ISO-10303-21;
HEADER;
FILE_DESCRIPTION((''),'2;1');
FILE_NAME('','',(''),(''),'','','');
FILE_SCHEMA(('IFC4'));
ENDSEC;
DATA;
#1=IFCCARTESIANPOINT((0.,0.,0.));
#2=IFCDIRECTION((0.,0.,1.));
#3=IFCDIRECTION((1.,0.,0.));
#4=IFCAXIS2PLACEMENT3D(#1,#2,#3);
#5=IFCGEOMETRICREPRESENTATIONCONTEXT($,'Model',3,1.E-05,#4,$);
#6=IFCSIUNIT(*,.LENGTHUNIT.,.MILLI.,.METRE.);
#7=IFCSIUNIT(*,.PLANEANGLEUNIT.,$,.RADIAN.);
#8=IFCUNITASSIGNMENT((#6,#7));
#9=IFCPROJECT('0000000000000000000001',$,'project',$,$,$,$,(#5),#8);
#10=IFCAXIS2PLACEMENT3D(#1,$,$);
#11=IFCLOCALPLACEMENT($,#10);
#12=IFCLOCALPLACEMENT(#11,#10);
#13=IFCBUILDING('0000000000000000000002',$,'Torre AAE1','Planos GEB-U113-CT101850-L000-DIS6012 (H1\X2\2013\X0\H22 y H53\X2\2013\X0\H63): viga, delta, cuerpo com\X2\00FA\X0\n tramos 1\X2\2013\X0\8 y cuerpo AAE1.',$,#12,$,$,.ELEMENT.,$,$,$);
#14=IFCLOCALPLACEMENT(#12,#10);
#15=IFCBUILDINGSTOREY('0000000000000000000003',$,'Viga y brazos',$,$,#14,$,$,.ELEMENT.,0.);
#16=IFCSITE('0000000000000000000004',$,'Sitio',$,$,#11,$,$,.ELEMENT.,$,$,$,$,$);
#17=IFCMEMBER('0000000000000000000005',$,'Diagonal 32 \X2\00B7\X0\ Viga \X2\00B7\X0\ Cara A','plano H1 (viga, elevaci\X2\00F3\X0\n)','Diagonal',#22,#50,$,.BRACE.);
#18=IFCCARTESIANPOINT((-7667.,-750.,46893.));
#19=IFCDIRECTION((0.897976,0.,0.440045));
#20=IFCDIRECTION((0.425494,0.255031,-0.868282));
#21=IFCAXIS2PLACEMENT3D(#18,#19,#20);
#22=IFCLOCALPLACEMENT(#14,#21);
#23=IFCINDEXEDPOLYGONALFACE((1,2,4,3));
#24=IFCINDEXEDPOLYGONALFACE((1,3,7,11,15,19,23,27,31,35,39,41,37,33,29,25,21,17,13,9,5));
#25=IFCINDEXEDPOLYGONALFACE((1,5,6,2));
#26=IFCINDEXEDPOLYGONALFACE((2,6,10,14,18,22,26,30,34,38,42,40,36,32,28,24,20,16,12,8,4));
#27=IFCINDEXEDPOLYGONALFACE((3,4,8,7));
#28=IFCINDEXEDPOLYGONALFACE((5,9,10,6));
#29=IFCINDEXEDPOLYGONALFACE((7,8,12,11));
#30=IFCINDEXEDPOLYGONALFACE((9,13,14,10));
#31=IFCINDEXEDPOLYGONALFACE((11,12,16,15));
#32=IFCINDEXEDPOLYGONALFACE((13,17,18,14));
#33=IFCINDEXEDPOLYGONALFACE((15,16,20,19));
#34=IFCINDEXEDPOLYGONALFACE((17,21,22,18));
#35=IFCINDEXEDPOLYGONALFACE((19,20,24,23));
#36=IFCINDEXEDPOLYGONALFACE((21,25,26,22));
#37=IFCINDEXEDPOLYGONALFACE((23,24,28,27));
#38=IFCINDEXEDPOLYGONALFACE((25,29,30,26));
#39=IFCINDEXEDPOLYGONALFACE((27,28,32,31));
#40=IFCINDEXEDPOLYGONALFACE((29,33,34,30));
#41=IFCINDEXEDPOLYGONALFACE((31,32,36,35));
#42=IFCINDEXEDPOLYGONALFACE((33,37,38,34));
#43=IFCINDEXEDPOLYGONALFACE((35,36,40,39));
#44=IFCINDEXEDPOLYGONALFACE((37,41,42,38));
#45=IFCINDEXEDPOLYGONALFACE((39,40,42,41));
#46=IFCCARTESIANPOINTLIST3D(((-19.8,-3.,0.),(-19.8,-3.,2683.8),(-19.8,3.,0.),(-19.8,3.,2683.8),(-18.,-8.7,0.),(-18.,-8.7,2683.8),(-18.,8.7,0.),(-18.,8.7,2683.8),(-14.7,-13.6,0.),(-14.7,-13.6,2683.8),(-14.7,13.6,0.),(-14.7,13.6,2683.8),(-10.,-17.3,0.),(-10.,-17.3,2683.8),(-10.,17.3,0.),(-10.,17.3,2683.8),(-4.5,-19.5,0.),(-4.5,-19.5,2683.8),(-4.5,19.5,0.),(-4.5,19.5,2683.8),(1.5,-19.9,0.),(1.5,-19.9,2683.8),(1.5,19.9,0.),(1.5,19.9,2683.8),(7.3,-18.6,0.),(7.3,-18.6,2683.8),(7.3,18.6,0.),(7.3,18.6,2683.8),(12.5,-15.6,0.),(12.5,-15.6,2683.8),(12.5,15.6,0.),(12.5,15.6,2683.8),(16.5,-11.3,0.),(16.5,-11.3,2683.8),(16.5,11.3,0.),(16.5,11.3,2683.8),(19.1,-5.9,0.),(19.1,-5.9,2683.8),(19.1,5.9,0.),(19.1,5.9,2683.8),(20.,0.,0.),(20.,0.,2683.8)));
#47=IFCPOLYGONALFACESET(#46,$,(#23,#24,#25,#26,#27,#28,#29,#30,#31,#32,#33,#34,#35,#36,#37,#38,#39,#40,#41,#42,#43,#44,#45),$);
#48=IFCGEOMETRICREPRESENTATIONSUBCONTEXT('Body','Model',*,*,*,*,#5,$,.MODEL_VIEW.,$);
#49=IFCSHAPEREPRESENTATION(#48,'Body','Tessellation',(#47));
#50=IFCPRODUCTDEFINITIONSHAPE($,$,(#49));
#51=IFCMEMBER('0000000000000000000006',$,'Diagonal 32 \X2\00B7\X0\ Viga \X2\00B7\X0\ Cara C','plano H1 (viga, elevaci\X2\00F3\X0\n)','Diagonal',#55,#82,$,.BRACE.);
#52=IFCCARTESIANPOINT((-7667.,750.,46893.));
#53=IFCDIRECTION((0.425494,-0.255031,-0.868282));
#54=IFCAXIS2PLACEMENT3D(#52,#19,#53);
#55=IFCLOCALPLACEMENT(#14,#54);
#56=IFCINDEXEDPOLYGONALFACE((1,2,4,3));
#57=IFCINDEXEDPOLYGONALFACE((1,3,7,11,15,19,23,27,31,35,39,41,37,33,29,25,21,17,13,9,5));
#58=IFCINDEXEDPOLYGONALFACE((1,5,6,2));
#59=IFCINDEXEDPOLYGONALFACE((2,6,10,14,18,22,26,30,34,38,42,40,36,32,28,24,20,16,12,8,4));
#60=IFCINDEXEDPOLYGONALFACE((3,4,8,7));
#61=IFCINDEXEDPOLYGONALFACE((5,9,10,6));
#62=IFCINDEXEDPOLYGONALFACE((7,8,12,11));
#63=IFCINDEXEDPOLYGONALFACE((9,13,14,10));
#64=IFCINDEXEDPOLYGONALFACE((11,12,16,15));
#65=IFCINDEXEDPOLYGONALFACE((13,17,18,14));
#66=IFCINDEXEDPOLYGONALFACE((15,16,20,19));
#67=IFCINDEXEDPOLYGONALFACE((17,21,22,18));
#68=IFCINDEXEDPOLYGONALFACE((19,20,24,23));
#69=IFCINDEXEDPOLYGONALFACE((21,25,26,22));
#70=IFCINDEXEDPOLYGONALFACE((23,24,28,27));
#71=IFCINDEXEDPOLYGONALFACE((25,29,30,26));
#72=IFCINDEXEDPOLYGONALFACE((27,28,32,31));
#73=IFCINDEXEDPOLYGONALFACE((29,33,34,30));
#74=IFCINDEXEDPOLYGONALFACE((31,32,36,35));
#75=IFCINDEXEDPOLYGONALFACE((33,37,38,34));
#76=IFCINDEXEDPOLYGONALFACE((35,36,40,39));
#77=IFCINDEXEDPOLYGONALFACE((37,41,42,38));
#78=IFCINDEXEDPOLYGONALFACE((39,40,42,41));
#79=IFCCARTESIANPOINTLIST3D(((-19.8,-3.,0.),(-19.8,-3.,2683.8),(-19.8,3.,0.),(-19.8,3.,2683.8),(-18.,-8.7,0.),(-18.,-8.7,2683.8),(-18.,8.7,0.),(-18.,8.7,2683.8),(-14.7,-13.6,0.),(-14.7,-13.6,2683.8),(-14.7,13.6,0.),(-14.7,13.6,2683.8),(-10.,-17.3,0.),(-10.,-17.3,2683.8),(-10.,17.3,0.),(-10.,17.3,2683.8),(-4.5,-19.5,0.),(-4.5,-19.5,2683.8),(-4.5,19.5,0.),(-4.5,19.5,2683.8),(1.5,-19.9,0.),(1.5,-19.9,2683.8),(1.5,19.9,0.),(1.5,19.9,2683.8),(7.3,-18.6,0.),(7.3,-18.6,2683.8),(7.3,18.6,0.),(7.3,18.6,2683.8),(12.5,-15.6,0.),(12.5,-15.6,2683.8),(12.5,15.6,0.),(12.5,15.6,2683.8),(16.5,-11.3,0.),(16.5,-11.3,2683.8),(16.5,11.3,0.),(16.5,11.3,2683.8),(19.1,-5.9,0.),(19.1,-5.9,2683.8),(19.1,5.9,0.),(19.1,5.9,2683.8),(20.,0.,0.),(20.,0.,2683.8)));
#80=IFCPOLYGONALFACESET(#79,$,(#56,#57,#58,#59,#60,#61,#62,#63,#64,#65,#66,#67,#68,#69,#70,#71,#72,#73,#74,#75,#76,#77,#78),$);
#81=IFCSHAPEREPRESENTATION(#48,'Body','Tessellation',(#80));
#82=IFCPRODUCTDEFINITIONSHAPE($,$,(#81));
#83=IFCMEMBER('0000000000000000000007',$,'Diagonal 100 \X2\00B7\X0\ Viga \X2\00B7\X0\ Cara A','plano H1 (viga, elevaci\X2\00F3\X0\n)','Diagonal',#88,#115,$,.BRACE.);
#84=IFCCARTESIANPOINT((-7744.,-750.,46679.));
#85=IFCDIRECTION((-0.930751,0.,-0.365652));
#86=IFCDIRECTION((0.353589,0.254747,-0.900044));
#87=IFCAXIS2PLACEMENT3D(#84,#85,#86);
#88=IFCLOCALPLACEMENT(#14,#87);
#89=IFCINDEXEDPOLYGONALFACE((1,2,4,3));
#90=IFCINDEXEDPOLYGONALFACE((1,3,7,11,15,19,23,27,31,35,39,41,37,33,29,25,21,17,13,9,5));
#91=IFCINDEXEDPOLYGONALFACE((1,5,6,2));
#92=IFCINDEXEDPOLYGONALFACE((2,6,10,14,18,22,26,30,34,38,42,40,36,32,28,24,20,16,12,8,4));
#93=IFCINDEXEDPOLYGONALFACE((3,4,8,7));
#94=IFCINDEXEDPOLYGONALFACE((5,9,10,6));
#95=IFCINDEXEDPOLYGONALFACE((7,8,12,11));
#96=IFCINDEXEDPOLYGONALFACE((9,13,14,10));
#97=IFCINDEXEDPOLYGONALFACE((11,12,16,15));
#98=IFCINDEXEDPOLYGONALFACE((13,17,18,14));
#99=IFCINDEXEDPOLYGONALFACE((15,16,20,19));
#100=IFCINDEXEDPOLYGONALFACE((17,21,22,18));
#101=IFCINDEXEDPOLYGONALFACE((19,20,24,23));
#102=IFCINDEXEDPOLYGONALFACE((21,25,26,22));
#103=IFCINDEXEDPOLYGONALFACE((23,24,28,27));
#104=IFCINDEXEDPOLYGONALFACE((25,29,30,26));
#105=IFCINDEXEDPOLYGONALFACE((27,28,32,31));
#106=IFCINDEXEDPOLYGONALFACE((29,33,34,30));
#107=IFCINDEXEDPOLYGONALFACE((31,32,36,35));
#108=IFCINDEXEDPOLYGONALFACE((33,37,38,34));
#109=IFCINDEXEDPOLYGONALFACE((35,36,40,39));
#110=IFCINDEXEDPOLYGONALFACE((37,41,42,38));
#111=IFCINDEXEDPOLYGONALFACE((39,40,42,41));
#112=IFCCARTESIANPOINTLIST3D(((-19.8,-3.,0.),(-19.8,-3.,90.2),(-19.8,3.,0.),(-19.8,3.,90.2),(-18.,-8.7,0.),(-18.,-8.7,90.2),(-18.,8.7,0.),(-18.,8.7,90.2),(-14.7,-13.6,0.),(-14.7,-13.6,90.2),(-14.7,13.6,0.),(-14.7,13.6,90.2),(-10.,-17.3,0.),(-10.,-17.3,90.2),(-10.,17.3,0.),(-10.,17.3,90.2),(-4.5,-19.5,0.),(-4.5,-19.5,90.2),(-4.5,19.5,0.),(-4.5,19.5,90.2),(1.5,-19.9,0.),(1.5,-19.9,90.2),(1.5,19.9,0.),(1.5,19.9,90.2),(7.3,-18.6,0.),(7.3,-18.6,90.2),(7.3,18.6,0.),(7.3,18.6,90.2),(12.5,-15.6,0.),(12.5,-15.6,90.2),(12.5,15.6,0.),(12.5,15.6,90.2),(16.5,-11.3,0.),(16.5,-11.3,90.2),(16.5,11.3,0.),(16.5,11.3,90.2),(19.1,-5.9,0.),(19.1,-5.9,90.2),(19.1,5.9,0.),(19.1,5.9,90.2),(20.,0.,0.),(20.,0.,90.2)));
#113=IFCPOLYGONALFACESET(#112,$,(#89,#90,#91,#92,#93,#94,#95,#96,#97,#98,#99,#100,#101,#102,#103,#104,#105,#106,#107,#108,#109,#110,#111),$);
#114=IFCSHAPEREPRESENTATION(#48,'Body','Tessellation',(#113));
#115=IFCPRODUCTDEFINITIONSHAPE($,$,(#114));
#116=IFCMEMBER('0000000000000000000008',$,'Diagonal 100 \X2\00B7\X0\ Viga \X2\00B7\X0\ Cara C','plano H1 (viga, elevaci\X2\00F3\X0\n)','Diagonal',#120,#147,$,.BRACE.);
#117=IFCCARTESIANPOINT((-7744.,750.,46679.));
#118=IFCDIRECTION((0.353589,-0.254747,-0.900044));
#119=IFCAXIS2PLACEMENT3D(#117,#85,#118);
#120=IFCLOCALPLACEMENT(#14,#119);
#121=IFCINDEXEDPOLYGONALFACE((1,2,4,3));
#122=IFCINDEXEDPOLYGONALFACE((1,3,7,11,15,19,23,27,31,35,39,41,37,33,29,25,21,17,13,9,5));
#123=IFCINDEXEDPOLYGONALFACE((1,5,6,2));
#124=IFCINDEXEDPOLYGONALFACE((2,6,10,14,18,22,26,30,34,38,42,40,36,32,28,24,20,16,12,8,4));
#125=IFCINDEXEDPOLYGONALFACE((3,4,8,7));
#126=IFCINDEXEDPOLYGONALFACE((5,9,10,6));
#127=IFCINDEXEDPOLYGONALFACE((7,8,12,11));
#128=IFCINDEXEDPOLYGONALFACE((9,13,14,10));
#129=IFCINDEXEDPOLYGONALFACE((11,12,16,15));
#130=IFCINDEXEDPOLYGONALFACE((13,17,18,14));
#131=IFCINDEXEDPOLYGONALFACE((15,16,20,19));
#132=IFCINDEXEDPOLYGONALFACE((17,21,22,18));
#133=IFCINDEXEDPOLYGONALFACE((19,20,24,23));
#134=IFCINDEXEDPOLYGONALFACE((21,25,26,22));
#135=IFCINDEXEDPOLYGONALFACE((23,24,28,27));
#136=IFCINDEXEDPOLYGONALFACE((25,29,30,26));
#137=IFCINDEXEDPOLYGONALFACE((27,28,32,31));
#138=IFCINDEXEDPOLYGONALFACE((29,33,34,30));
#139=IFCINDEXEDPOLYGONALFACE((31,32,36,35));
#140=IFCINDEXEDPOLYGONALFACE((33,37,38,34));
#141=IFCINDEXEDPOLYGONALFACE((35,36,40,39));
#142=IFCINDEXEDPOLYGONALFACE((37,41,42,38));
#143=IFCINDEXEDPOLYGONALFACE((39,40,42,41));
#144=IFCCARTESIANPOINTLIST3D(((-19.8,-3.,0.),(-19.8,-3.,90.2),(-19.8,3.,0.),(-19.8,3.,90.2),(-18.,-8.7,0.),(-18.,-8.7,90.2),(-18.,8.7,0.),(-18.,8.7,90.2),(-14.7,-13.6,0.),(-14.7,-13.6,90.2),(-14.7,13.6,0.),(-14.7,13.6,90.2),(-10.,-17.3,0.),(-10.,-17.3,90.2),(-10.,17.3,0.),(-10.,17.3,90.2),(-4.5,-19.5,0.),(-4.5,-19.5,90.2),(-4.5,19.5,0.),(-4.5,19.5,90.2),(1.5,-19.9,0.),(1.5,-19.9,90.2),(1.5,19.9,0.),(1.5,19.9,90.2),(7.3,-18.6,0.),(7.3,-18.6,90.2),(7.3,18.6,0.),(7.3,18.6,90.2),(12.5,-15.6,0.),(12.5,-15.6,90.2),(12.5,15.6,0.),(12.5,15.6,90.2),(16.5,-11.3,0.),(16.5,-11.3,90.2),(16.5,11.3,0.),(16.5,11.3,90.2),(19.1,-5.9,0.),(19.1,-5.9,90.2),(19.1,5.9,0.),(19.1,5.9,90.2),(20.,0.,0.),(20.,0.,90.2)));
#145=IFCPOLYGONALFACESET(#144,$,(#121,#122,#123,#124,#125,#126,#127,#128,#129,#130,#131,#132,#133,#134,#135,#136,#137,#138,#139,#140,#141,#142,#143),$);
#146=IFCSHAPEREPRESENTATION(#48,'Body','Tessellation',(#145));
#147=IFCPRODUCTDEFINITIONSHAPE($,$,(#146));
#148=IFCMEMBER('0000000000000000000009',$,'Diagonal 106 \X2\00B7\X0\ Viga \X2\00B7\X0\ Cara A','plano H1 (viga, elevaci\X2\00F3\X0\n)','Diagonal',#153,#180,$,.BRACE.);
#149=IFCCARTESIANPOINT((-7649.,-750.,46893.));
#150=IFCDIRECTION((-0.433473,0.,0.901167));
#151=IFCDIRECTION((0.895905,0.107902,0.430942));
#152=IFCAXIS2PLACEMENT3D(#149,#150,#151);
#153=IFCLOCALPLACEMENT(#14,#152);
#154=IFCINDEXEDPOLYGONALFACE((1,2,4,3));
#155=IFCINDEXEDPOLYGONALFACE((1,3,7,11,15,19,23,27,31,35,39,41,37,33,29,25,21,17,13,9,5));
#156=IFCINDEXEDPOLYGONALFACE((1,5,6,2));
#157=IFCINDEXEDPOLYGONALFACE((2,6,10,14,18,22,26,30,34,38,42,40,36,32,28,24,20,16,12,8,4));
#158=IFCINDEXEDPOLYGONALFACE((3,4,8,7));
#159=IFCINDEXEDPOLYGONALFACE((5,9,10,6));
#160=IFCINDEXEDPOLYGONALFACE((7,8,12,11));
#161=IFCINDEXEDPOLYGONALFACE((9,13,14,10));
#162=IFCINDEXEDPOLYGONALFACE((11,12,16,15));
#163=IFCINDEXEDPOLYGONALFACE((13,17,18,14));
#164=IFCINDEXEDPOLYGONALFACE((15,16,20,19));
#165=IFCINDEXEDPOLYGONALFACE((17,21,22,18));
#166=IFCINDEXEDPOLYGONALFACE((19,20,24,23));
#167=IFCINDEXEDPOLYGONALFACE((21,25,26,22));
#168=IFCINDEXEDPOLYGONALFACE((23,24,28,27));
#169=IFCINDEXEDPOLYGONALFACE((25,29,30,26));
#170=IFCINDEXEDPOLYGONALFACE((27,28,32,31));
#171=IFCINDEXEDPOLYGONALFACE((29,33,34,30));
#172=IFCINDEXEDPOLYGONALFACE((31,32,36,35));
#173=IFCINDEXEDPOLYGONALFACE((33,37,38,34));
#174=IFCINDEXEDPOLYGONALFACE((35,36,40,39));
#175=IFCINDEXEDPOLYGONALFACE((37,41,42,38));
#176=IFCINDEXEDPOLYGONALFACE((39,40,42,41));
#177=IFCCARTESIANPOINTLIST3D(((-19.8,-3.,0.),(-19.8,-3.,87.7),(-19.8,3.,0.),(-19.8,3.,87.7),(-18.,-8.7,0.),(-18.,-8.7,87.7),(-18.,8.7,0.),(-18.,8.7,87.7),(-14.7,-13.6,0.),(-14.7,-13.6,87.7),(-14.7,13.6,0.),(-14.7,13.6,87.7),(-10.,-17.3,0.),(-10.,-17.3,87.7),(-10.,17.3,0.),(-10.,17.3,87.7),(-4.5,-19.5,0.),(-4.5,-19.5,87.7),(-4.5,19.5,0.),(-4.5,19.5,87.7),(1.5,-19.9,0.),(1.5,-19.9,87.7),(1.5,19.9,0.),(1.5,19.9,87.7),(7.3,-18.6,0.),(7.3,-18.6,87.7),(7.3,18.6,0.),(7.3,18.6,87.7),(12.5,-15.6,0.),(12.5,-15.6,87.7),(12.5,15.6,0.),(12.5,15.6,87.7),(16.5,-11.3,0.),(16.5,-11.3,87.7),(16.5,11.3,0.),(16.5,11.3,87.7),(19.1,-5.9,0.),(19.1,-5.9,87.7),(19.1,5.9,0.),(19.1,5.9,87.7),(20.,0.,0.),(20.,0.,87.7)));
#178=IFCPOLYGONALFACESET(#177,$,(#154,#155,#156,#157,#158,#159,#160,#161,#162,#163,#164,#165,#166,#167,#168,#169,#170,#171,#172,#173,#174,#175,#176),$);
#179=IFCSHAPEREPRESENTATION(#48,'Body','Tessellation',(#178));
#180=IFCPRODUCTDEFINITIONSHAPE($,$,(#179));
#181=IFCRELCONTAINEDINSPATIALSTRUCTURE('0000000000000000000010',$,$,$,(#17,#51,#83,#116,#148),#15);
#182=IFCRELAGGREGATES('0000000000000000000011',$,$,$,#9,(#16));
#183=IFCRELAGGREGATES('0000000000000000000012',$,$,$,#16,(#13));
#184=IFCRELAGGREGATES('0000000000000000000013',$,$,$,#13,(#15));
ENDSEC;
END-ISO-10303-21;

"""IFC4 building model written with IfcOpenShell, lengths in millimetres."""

from ifc_helpers import new_model, si_unit, frame, origin, origin_with_axes, place, context, subcontext, project, spatial, circle, extrude, element, save


model = new_model("IFC4")

# Units and contexts
model_context = context("Model", 3, precision=1e-05, world=origin_with_axes())
body_context = subcontext(model_context, "Body", "Model", "MODEL_VIEW")
ifc_project = project(units=[si_unit("LENGTHUNIT", "METRE", prefix="MILLI"), si_unit("PLANEANGLEUNIT", "RADIAN")], contexts=[model_context])

# Site, building, storey
site_placement = place(None, origin())
site = spatial("IfcSite", under=ifc_project, at=site_placement, Name="Sitio", CompositionType="ELEMENT")
building_placement = place(site_placement, origin())
building = spatial("IfcBuilding", under=site, at=building_placement, Name="Torre AAE1", Description="Planos GEB-U113-CT101850-L000-DIS6012 (H1–H22 y H53–H63): viga, delta, cuerpo común tramos 1–8 y cuerpo AAE1.", CompositionType="ELEMENT")
storey_placement = place(building_placement, origin())
storey = spatial("IfcBuildingStorey", under=building, at=storey_placement, Name="Viga y brazos", CompositionType="ELEMENT", Elevation=0.0)

# Members
for number, where, z_axis, x_axis, name in (
    (1, (-7667.0, -750.0, 46893.0), (0.897976, 0.0, 0.440045), (0.425494, 0.255031, -0.868282), "Diagonal 32 · Viga · Cara A"),
    (2, (-7667.0, 750.0, 46893.0), (0.897976, 0.0, 0.440045), (0.425494, -0.255031, -0.868282), "Diagonal 32 · Viga · Cara C"),
):
    element("IfcMember", number, at=place(storey_placement, frame(where, z_axis=z_axis, x_axis=x_axis)), inside=storey, Name=name, Description="plano H1 (viga, elevación)", ObjectType="Diagonal", PredefinedType="BRACE", context=body_context, shape_type="SweptSolid", body=[
        extrude(circle(Radius=20.0), None, (0.0, 0.0, 1.0), 2683.8),
    ])
for number, where, z_axis, x_axis, name in (
    (3, (-7744.0, -750.0, 46679.0), (-0.930751, 0.0, -0.365652), (0.353589, 0.254747, -0.900044), "Diagonal 100 · Viga · Cara A"),
    (4, (-7744.0, 750.0, 46679.0), (-0.930751, 0.0, -0.365652), (0.353589, -0.254747, -0.900044), "Diagonal 100 · Viga · Cara C"),
):
    element("IfcMember", number, at=place(storey_placement, frame(where, z_axis=z_axis, x_axis=x_axis)), inside=storey, Name=name, Description="plano H1 (viga, elevación)", ObjectType="Diagonal", PredefinedType="BRACE", context=body_context, shape_type="SweptSolid", body=[
        extrude(circle(Radius=20.0), None, (0.0, 0.0, 1.0), 90.2),
    ])
member_1_placement = place(storey_placement, frame((-7649.0, -750.0, 46893.0), z_axis=(-0.433473, 0.0, 0.901167), x_axis=(0.895905, 0.107902, 0.430942)))
element("IfcMember", 5, at=member_1_placement, inside=storey, Name="Diagonal 106 · Viga · Cara A", Description="plano H1 (viga, elevación)", ObjectType="Diagonal", PredefinedType="BRACE", context=body_context, shape_type="SweptSolid", body=[
    extrude(circle(Radius=20.0), None, (0.0, 0.0, 1.0), 87.7),
])

save(model, "model.ifc")
